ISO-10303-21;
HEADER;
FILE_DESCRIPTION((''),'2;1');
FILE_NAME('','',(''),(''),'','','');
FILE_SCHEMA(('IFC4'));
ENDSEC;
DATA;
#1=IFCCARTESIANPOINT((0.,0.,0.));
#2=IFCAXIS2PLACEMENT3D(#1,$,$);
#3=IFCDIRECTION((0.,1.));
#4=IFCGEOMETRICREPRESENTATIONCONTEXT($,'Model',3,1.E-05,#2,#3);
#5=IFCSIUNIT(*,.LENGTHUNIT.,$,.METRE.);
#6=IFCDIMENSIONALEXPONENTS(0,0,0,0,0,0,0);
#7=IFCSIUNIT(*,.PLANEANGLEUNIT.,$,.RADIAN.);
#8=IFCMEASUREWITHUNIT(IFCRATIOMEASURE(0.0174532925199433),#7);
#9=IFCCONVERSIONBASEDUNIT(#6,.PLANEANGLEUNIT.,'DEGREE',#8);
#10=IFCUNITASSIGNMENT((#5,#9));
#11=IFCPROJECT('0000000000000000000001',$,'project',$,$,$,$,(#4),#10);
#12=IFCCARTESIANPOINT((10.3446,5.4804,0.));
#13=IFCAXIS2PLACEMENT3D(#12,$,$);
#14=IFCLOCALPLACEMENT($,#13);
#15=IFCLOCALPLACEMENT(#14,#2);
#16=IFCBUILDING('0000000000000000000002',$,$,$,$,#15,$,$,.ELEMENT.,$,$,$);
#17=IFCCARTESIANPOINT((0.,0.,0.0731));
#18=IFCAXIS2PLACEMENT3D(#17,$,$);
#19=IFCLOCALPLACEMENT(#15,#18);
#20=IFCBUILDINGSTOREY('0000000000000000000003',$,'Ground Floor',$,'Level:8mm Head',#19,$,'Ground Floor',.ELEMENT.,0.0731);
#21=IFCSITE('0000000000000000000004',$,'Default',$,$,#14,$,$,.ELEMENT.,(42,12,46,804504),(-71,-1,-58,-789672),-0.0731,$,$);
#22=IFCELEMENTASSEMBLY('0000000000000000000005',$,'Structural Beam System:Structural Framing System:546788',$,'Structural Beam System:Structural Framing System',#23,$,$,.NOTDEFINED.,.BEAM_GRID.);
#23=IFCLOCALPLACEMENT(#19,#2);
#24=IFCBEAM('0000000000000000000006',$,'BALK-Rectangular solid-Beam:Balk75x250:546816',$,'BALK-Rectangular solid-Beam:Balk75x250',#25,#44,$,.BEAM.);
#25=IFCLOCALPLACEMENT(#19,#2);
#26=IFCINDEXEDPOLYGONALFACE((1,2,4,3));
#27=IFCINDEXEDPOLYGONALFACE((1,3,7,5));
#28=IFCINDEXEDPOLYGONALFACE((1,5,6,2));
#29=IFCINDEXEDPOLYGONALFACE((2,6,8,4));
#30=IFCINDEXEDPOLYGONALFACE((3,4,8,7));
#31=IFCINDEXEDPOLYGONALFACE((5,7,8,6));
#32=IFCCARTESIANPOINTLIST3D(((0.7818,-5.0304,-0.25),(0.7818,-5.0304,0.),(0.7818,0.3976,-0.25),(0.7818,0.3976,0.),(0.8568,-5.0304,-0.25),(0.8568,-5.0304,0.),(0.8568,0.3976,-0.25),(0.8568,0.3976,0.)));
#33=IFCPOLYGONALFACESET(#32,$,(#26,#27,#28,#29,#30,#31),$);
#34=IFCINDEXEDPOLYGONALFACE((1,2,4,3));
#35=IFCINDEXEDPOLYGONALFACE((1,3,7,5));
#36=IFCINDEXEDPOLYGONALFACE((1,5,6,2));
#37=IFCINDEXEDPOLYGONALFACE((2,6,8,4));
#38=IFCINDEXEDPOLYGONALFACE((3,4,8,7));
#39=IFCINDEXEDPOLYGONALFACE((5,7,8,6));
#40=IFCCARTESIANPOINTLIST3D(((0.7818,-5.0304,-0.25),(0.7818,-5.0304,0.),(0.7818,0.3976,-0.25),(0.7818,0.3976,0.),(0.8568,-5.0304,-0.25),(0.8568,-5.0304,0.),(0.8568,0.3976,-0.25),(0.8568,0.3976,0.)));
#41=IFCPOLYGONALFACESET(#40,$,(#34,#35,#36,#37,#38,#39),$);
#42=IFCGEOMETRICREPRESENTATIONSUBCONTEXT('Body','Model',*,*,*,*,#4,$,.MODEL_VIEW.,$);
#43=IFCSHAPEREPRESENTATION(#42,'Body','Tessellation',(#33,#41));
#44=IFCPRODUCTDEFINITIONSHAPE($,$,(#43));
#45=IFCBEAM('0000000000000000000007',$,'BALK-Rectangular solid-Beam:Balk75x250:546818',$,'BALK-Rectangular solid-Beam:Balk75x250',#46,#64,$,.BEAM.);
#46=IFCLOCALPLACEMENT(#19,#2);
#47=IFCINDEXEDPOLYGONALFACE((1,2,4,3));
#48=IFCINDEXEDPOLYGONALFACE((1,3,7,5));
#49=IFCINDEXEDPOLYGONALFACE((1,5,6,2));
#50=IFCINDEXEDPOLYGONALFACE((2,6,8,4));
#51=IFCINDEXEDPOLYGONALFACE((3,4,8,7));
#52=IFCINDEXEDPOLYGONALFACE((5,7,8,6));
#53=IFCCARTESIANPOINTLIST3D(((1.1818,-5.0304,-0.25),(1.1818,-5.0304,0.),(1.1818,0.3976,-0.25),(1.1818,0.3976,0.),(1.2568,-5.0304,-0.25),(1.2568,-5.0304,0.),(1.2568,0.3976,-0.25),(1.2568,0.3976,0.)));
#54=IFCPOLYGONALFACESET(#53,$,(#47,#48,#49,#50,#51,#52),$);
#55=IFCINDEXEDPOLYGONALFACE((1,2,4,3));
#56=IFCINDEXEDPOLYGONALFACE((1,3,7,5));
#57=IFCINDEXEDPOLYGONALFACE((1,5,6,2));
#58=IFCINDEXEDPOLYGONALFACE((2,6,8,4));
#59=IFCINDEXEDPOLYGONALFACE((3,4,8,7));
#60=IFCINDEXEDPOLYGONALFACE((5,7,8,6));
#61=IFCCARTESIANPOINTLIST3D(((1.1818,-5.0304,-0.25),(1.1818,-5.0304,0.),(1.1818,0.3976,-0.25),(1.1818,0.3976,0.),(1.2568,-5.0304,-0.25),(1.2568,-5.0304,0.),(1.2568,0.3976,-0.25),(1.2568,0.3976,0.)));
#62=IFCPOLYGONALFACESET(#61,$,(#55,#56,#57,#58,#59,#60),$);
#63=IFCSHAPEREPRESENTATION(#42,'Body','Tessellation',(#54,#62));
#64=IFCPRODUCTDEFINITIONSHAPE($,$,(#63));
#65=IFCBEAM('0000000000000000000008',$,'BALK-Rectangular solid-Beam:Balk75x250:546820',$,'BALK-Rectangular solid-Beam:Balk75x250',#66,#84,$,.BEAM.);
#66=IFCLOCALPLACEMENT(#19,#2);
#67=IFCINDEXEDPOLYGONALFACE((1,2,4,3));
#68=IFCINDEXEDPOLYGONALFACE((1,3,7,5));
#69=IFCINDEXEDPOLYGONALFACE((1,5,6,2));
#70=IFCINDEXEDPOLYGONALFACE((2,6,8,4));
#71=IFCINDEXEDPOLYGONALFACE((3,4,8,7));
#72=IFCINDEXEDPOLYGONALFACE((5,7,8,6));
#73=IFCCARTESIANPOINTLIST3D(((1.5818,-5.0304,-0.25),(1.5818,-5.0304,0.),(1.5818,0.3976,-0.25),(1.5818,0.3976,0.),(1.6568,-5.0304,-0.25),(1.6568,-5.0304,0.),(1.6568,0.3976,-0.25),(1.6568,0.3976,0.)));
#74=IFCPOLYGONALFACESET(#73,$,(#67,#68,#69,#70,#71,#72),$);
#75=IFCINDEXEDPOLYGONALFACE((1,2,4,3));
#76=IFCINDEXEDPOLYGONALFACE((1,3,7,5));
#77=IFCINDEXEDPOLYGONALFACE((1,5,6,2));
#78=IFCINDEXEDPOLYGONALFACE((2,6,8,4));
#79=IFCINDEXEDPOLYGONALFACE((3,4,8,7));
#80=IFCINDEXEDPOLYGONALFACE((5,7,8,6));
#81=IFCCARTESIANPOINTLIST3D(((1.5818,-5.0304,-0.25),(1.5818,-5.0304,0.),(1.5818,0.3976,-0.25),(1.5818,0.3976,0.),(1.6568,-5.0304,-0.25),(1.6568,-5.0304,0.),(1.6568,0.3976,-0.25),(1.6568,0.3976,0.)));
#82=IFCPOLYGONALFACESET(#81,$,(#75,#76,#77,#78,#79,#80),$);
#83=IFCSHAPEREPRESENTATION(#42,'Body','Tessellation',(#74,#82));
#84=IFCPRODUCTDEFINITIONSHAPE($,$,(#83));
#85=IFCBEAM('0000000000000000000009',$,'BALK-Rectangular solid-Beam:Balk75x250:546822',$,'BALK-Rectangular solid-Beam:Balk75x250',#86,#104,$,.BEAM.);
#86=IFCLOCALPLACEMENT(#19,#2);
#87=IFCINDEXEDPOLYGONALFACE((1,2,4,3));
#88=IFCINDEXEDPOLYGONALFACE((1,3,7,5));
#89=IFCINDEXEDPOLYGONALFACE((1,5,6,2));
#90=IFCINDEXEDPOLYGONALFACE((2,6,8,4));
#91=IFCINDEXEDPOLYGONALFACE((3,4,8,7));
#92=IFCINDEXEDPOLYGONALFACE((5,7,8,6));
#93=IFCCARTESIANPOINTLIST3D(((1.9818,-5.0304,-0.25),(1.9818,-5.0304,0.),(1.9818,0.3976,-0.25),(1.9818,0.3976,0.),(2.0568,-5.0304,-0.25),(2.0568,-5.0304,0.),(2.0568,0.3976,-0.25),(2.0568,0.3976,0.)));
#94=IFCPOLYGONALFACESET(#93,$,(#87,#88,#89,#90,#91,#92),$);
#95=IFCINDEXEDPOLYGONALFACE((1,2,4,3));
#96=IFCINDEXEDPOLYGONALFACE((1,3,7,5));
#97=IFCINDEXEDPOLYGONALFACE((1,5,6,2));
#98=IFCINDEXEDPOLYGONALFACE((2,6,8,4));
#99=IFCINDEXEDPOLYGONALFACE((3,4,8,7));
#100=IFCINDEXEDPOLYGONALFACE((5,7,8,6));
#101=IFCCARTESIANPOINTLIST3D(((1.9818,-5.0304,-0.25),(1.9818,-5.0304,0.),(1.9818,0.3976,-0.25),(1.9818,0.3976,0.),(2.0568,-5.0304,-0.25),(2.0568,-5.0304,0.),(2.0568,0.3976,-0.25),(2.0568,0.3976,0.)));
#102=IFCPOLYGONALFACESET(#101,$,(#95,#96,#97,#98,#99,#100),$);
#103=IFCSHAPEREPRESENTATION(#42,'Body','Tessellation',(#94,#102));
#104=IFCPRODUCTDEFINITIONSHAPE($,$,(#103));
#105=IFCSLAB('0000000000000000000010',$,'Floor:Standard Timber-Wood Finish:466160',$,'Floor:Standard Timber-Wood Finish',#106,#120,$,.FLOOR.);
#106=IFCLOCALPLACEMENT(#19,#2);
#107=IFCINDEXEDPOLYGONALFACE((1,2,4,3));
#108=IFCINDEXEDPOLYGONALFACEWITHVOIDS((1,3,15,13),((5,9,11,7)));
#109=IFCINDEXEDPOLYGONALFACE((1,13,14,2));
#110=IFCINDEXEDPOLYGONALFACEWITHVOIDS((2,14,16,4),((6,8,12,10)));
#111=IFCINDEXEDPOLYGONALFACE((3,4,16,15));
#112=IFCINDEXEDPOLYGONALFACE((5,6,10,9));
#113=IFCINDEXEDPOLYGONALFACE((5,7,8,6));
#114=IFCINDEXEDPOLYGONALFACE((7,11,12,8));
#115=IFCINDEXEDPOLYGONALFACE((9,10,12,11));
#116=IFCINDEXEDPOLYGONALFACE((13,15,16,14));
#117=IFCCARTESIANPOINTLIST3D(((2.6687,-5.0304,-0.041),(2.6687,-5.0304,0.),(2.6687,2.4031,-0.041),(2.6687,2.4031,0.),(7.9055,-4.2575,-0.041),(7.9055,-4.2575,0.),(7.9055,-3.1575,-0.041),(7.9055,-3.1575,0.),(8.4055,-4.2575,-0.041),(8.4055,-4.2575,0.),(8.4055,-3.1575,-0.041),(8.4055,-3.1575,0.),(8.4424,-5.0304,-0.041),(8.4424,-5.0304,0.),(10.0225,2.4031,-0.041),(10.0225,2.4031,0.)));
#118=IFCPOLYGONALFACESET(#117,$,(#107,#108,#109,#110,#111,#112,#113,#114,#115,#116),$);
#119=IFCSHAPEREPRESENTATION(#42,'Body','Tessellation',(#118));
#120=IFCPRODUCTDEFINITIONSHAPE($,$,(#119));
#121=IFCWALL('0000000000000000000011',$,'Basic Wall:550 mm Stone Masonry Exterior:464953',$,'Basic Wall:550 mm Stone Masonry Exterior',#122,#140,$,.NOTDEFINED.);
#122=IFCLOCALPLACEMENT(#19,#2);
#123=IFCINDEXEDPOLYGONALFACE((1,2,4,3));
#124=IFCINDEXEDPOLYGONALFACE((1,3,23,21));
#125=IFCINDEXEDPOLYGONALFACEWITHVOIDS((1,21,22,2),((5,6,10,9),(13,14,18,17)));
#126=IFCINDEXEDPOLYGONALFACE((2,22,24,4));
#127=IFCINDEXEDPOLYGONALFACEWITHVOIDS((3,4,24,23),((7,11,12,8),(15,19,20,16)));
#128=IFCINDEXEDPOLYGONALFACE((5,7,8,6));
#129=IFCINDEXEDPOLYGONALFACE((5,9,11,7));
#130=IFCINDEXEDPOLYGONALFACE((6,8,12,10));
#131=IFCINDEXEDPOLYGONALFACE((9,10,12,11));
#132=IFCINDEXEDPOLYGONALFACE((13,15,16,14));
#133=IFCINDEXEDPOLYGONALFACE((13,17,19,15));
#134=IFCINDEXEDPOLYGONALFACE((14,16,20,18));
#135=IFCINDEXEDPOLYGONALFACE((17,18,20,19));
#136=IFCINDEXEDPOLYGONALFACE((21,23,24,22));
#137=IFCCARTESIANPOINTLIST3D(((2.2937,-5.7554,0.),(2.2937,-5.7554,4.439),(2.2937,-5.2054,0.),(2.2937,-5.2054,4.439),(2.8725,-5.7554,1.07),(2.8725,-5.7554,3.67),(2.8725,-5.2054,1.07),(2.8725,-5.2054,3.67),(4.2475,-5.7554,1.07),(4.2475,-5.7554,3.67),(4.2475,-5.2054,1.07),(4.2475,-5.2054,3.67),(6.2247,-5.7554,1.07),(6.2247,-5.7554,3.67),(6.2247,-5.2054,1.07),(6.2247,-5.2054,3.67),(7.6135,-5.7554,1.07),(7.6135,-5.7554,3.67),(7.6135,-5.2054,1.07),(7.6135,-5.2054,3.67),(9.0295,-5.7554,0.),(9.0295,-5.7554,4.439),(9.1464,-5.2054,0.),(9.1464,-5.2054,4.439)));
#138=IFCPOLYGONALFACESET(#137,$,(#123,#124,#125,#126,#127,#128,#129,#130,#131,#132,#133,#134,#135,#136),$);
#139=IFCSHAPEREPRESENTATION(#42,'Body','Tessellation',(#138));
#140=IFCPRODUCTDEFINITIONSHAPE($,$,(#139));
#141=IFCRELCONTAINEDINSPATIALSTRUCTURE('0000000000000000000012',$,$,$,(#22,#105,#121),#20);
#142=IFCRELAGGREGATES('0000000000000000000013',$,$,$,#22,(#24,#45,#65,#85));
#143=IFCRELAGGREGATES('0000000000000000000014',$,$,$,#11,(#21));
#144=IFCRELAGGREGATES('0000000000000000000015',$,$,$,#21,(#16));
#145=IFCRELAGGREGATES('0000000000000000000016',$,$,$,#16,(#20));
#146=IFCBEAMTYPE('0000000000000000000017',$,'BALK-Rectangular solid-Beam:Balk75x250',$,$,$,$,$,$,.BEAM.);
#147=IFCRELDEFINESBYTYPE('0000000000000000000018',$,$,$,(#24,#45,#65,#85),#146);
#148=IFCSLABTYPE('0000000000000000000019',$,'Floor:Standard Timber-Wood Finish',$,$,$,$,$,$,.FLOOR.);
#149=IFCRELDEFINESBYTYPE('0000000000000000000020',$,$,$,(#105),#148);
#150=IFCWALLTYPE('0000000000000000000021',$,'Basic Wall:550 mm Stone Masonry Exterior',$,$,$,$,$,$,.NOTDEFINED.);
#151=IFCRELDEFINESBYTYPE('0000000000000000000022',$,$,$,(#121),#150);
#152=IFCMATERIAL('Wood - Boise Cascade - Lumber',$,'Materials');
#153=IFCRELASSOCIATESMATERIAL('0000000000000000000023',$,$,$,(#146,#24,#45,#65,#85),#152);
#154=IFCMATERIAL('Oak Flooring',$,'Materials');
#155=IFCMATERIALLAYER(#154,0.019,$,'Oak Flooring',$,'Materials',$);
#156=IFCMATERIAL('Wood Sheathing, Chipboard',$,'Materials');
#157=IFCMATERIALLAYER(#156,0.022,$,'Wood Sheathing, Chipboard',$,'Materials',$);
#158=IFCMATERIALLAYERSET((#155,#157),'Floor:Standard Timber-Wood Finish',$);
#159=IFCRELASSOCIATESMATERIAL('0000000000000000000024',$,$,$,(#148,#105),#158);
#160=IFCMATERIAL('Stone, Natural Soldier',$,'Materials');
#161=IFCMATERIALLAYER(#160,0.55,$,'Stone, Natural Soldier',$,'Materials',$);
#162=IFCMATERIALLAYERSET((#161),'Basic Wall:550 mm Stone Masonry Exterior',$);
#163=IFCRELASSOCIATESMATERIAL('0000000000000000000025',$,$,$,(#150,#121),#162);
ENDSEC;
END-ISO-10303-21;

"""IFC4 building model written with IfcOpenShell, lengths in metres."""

from ifc_helpers import new_model, entity, si_unit, converted_unit, direction, frame, frame_2d, origin, origin_2d_with_axis, place, context, subcontext, project, spatial, polyline, rectangle, outline, extrude, source, transform, mapped, material, layer, layer_set, layer_usage, material_profile, profile_set, profile_usage, type_object, type_shapes, element, aggregate, save


model = new_model("IFC4")

# Units and contexts
model_context = context("Model", 3, precision=1e-05, world=origin(), true_north=direction((0.0, 1.0)))
body_context = subcontext(model_context, "Body", "Model", "MODEL_VIEW")
ifc_project = project(units=[si_unit("LENGTHUNIT", "METRE"), converted_unit("PLANEANGLEUNIT", "DEGREE", entity("IfcRatioMeasure", 0.0174532925199433), si_unit("PLANEANGLEUNIT", "RADIAN"), dimensions=[0, 0, 0, 0, 0, 0, 0])], contexts=[model_context])

# Site, building, storey
site_placement = place(None, frame((10.3446, 5.4804, 0.0)))
site = spatial("IfcSite", under=ifc_project, at=site_placement, Name="Default", CompositionType="ELEMENT", RefLatitude=(42, 12, 46, 804504), RefLongitude=(-71, -1, -58, -789672), RefElevation=-0.0731)
building_placement = place(site_placement, origin())
building = spatial("IfcBuilding", under=site, at=building_placement, CompositionType="ELEMENT")
storey_placement = place(building_placement, frame((0.0, 0.0, 0.0731)))
storey = spatial("IfcBuildingStorey", under=building, at=storey_placement, Name="Ground Floor", ObjectType="Level:8mm Head", LongName="Ground Floor", CompositionType="ELEMENT", Elevation=0.0731)

# Element assembly, beams
ifc_material_1 = material(Name="Wood - Boise Cascade - Lumber", Category="Materials")
ifc_material_profile = material_profile(ifc_material_1, rectangle(XDim=0.25, YDim=0.075, at=frame_2d((0.0, 0.0), x_axis=(1.0, 0.0))), Name="Balk75x250")
ifc_profile_set = profile_set([ifc_material_profile], Name="Balk75x250")
assembly_1_placement = place(storey_placement, origin())
assembly_1 = element("IfcElementAssembly", 1, at=assembly_1_placement, inside=storey, Name="Structural Beam System:Structural Framing System:546788", ObjectType="Structural Beam System:Structural Framing System", AssemblyPlace="NOTDEFINED", PredefinedType="BEAM_GRID")
ifc_profile_usage_1 = profile_usage(ifc_profile_set, cardinal=8)
beam_type_1 = type_object("IfcBeamType", Name="BALK-Rectangular solid-Beam:Balk75x250", PredefinedType="BEAM", material=ifc_profile_set)
shared_shape_1 = source(origin(), body_context, "Body", "SweptSolid", [
    extrude(rectangle(XDim=0.25, YDim=0.075, at=origin_2d_with_axis()), frame((-2.5203, 0.0, 0.0), z_axis=(1.0, 0.0, 0.0), x_axis=(0.0, 0.0, -1.0)), (0.0, 0.0, 1.0), 5.428),
    extrude(rectangle(XDim=0.25, YDim=0.075, at=origin_2d_with_axis()), frame((-2.5203, 0.0, 0.0), z_axis=(1.0, 0.0, 0.0), x_axis=(0.0, 0.0, -1.0)), (0.0, 0.0, 1.0), 5.428),
])
type_shapes(beam_type_1, [shared_shape_1])
beam_1_placement = place(assembly_1_placement, frame((0.8193, -2.5102, -0.125), z_axis=(0.0, 0.0, 1.0), x_axis=(0.0, 1.0, 0.0)))
beam_1 = element("IfcBeam", 2, at=beam_1_placement, type_object=beam_type_1, material=ifc_profile_usage_1, Name="BALK-Rectangular solid-Beam:Balk75x250:546816", ObjectType="BALK-Rectangular solid-Beam:Balk75x250", PredefinedType="BEAM", context=body_context, shape_type="MappedRepresentation", body=[
    mapped(shared_shape_1, transform((0.0, 0.0, 0.0), scale=1.0)),
])
ifc_profile_usage_2 = profile_usage(ifc_profile_set, cardinal=8)
beam_2_placement = place(assembly_1_placement, frame((1.2193, -2.5102, -0.125), z_axis=(0.0, 0.0, 1.0), x_axis=(0.0, 1.0, 0.0)))
beam_2 = element("IfcBeam", 3, at=beam_2_placement, type_object=beam_type_1, material=ifc_profile_usage_2, Name="BALK-Rectangular solid-Beam:Balk75x250:546818", ObjectType="BALK-Rectangular solid-Beam:Balk75x250", PredefinedType="BEAM", context=body_context, shape_type="MappedRepresentation", body=[
    mapped(shared_shape_1, transform((0.0, 0.0, 0.0), scale=1.0)),
])
ifc_profile_usage_3 = profile_usage(ifc_profile_set, cardinal=8)
beam_3_placement = place(assembly_1_placement, frame((1.6193, -2.5102, -0.125), z_axis=(0.0, 0.0, 1.0), x_axis=(0.0, 1.0, 0.0)))
beam_3 = element("IfcBeam", 4, at=beam_3_placement, type_object=beam_type_1, material=ifc_profile_usage_3, Name="BALK-Rectangular solid-Beam:Balk75x250:546820", ObjectType="BALK-Rectangular solid-Beam:Balk75x250", PredefinedType="BEAM", context=body_context, shape_type="MappedRepresentation", body=[
    mapped(shared_shape_1, transform((0.0, 0.0, 0.0), scale=1.0)),
])
ifc_profile_usage_4 = profile_usage(ifc_profile_set, cardinal=8)
beam_4_placement = place(assembly_1_placement, frame((2.0193, -2.5102, -0.125), z_axis=(0.0, 0.0, 1.0), x_axis=(0.0, 1.0, 0.0)))
beam_4 = element("IfcBeam", 5, at=beam_4_placement, type_object=beam_type_1, material=ifc_profile_usage_4, Name="BALK-Rectangular solid-Beam:Balk75x250:546822", ObjectType="BALK-Rectangular solid-Beam:Balk75x250", PredefinedType="BEAM", context=body_context, shape_type="MappedRepresentation", body=[
    mapped(shared_shape_1, transform((0.0, 0.0, 0.0), scale=1.0)),
])
aggregate(assembly_1, [beam_1, beam_2, beam_3, beam_4])

# Slab, opening
ifc_material_2 = material(Name="Oak Flooring", Category="Materials")
ifc_layer_1 = layer(ifc_material_2, 0.019, Name="Oak Flooring", Category="Materials")
ifc_material_3 = material(Name="Wood Sheathing, Chipboard", Category="Materials")
ifc_layer_2 = layer(ifc_material_3, 0.022, Name="Wood Sheathing, Chipboard", Category="Materials")
ifc_layer_set_1 = layer_set([ifc_layer_1, ifc_layer_2], Name="Floor:Standard Timber-Wood Finish")
ifc_layer_usage_1 = layer_usage(ifc_layer_set_1, "AXIS3", "POSITIVE", 0.0)
slab_type = type_object("IfcSlabType", Name="Floor:Standard Timber-Wood Finish", PredefinedType="FLOOR", material=ifc_layer_set_1)
slab_placement = place(storey_placement, frame((2.6687, -5.0304, -0.041)))
slab = element("IfcSlab", 6, at=slab_placement, inside=storey, type_object=slab_type, material=ifc_layer_usage_1, Name="Floor:Standard Timber-Wood Finish:466160", ObjectType="Floor:Standard Timber-Wood Finish", PredefinedType="FLOOR", context=body_context, shape_type="SweptSolid", body=[
    extrude(outline(polyline([(-2.0969, -3.7168), (3.6769, -3.7168), (3.6769, 3.7168), (-3.6769, 3.7168), (-2.0969, -3.7168)])), frame((3.6769, 3.7168, 0.041), z_axis=(0.0, 0.0, -1.0), x_axis=(-1.0, 0.0, 0.0)), (0.0, 0.0, 1.0), 0.041),
])
opening_1_placement = place(storey_placement, frame((2.6687, -5.0304, -0.041)))
element("IfcOpeningElement", 7, at=opening_1_placement, cuts=slab, ObjectType="Opening", context=body_context, shape_type="SweptSolid", body=[
    extrude(rectangle(XDim=1.1, YDim=0.5, at=frame_2d((-1.8099, -2.3938), x_axis=(0.0, -1.0))), frame((3.6769, 3.7168, 0.041), z_axis=(0.0, 0.0, -1.0), x_axis=(-1.0, 0.0, 0.0)), (0.0, 0.0, 1.0), 0.041),
])

# Wall, openings
ifc_material_4 = material(Name="Stone, Natural Soldier", Category="Materials")
ifc_layer_3 = layer(ifc_material_4, 0.55, Name="Stone, Natural Soldier", Category="Materials")
ifc_layer_set_2 = layer_set([ifc_layer_3], Name="Basic Wall:550 mm Stone Masonry Exterior")
wall_type = type_object("IfcWallType", Name="Basic Wall:550 mm Stone Masonry Exterior", PredefinedType="NOTDEFINED", material=ifc_layer_set_2)
ifc_layer_usage_2 = layer_usage(ifc_layer_set_2, "AXIS2", "NEGATIVE", 0.275)
wall_1_placement = place(storey_placement, frame((2.2937, -5.4804, 0.0)))
wall_1 = element("IfcWall", 8, at=wall_1_placement, inside=storey, type_object=wall_type, material=ifc_layer_usage_2, Name="Basic Wall:550 mm Stone Masonry Exterior:464953", ObjectType="Basic Wall:550 mm Stone Masonry Exterior", PredefinedType="NOTDEFINED", context=body_context, shape_type="SweptSolid", body=[
    extrude(outline(polyline([(6.7359, -0.275), (6.8528, 0.275), (6.2905, 0.275), (0.275, 0.275), (0.0, 0.275), (0.0, -0.275), (6.7359, -0.275)])), origin(), (0.0, 0.0, 1.0), 4.439),
])
opening_2_placement = place(wall_1_placement, frame((0.5788, -0.275, 1.07)))
element("IfcOpeningElement", 9, at=opening_2_placement, cuts=wall_1, ObjectType="Opening", PredefinedType="OPENING", context=body_context, shape_type="SweptSolid", body=[
    extrude(rectangle(XDim=2.6, YDim=1.375, at=frame_2d((0.0, 0.0), x_axis=(1.0, 0.0))), frame((0.6875, 0.0, 1.3), z_axis=(0.0, 1.0, 0.0), x_axis=(0.0, 0.0, -1.0)), (0.0, 0.0, 1.0), 0.55),
])
opening_3_placement = place(wall_1_placement, frame((3.9311, -0.275, 1.07)))
element("IfcOpeningElement", 10, at=opening_3_placement, cuts=wall_1, ObjectType="Opening", PredefinedType="OPENING", context=body_context, shape_type="SweptSolid", body=[
    extrude(rectangle(XDim=2.6, YDim=1.3887, at=frame_2d((0.0, 0.0), x_axis=(1.0, 0.0))), frame((0.6944, 0.0, 1.3), z_axis=(0.0, 1.0, 0.0), x_axis=(0.0, 0.0, -1.0)), (0.0, 0.0, 1.0), 0.55),
])

save(model, "model.ifc")
